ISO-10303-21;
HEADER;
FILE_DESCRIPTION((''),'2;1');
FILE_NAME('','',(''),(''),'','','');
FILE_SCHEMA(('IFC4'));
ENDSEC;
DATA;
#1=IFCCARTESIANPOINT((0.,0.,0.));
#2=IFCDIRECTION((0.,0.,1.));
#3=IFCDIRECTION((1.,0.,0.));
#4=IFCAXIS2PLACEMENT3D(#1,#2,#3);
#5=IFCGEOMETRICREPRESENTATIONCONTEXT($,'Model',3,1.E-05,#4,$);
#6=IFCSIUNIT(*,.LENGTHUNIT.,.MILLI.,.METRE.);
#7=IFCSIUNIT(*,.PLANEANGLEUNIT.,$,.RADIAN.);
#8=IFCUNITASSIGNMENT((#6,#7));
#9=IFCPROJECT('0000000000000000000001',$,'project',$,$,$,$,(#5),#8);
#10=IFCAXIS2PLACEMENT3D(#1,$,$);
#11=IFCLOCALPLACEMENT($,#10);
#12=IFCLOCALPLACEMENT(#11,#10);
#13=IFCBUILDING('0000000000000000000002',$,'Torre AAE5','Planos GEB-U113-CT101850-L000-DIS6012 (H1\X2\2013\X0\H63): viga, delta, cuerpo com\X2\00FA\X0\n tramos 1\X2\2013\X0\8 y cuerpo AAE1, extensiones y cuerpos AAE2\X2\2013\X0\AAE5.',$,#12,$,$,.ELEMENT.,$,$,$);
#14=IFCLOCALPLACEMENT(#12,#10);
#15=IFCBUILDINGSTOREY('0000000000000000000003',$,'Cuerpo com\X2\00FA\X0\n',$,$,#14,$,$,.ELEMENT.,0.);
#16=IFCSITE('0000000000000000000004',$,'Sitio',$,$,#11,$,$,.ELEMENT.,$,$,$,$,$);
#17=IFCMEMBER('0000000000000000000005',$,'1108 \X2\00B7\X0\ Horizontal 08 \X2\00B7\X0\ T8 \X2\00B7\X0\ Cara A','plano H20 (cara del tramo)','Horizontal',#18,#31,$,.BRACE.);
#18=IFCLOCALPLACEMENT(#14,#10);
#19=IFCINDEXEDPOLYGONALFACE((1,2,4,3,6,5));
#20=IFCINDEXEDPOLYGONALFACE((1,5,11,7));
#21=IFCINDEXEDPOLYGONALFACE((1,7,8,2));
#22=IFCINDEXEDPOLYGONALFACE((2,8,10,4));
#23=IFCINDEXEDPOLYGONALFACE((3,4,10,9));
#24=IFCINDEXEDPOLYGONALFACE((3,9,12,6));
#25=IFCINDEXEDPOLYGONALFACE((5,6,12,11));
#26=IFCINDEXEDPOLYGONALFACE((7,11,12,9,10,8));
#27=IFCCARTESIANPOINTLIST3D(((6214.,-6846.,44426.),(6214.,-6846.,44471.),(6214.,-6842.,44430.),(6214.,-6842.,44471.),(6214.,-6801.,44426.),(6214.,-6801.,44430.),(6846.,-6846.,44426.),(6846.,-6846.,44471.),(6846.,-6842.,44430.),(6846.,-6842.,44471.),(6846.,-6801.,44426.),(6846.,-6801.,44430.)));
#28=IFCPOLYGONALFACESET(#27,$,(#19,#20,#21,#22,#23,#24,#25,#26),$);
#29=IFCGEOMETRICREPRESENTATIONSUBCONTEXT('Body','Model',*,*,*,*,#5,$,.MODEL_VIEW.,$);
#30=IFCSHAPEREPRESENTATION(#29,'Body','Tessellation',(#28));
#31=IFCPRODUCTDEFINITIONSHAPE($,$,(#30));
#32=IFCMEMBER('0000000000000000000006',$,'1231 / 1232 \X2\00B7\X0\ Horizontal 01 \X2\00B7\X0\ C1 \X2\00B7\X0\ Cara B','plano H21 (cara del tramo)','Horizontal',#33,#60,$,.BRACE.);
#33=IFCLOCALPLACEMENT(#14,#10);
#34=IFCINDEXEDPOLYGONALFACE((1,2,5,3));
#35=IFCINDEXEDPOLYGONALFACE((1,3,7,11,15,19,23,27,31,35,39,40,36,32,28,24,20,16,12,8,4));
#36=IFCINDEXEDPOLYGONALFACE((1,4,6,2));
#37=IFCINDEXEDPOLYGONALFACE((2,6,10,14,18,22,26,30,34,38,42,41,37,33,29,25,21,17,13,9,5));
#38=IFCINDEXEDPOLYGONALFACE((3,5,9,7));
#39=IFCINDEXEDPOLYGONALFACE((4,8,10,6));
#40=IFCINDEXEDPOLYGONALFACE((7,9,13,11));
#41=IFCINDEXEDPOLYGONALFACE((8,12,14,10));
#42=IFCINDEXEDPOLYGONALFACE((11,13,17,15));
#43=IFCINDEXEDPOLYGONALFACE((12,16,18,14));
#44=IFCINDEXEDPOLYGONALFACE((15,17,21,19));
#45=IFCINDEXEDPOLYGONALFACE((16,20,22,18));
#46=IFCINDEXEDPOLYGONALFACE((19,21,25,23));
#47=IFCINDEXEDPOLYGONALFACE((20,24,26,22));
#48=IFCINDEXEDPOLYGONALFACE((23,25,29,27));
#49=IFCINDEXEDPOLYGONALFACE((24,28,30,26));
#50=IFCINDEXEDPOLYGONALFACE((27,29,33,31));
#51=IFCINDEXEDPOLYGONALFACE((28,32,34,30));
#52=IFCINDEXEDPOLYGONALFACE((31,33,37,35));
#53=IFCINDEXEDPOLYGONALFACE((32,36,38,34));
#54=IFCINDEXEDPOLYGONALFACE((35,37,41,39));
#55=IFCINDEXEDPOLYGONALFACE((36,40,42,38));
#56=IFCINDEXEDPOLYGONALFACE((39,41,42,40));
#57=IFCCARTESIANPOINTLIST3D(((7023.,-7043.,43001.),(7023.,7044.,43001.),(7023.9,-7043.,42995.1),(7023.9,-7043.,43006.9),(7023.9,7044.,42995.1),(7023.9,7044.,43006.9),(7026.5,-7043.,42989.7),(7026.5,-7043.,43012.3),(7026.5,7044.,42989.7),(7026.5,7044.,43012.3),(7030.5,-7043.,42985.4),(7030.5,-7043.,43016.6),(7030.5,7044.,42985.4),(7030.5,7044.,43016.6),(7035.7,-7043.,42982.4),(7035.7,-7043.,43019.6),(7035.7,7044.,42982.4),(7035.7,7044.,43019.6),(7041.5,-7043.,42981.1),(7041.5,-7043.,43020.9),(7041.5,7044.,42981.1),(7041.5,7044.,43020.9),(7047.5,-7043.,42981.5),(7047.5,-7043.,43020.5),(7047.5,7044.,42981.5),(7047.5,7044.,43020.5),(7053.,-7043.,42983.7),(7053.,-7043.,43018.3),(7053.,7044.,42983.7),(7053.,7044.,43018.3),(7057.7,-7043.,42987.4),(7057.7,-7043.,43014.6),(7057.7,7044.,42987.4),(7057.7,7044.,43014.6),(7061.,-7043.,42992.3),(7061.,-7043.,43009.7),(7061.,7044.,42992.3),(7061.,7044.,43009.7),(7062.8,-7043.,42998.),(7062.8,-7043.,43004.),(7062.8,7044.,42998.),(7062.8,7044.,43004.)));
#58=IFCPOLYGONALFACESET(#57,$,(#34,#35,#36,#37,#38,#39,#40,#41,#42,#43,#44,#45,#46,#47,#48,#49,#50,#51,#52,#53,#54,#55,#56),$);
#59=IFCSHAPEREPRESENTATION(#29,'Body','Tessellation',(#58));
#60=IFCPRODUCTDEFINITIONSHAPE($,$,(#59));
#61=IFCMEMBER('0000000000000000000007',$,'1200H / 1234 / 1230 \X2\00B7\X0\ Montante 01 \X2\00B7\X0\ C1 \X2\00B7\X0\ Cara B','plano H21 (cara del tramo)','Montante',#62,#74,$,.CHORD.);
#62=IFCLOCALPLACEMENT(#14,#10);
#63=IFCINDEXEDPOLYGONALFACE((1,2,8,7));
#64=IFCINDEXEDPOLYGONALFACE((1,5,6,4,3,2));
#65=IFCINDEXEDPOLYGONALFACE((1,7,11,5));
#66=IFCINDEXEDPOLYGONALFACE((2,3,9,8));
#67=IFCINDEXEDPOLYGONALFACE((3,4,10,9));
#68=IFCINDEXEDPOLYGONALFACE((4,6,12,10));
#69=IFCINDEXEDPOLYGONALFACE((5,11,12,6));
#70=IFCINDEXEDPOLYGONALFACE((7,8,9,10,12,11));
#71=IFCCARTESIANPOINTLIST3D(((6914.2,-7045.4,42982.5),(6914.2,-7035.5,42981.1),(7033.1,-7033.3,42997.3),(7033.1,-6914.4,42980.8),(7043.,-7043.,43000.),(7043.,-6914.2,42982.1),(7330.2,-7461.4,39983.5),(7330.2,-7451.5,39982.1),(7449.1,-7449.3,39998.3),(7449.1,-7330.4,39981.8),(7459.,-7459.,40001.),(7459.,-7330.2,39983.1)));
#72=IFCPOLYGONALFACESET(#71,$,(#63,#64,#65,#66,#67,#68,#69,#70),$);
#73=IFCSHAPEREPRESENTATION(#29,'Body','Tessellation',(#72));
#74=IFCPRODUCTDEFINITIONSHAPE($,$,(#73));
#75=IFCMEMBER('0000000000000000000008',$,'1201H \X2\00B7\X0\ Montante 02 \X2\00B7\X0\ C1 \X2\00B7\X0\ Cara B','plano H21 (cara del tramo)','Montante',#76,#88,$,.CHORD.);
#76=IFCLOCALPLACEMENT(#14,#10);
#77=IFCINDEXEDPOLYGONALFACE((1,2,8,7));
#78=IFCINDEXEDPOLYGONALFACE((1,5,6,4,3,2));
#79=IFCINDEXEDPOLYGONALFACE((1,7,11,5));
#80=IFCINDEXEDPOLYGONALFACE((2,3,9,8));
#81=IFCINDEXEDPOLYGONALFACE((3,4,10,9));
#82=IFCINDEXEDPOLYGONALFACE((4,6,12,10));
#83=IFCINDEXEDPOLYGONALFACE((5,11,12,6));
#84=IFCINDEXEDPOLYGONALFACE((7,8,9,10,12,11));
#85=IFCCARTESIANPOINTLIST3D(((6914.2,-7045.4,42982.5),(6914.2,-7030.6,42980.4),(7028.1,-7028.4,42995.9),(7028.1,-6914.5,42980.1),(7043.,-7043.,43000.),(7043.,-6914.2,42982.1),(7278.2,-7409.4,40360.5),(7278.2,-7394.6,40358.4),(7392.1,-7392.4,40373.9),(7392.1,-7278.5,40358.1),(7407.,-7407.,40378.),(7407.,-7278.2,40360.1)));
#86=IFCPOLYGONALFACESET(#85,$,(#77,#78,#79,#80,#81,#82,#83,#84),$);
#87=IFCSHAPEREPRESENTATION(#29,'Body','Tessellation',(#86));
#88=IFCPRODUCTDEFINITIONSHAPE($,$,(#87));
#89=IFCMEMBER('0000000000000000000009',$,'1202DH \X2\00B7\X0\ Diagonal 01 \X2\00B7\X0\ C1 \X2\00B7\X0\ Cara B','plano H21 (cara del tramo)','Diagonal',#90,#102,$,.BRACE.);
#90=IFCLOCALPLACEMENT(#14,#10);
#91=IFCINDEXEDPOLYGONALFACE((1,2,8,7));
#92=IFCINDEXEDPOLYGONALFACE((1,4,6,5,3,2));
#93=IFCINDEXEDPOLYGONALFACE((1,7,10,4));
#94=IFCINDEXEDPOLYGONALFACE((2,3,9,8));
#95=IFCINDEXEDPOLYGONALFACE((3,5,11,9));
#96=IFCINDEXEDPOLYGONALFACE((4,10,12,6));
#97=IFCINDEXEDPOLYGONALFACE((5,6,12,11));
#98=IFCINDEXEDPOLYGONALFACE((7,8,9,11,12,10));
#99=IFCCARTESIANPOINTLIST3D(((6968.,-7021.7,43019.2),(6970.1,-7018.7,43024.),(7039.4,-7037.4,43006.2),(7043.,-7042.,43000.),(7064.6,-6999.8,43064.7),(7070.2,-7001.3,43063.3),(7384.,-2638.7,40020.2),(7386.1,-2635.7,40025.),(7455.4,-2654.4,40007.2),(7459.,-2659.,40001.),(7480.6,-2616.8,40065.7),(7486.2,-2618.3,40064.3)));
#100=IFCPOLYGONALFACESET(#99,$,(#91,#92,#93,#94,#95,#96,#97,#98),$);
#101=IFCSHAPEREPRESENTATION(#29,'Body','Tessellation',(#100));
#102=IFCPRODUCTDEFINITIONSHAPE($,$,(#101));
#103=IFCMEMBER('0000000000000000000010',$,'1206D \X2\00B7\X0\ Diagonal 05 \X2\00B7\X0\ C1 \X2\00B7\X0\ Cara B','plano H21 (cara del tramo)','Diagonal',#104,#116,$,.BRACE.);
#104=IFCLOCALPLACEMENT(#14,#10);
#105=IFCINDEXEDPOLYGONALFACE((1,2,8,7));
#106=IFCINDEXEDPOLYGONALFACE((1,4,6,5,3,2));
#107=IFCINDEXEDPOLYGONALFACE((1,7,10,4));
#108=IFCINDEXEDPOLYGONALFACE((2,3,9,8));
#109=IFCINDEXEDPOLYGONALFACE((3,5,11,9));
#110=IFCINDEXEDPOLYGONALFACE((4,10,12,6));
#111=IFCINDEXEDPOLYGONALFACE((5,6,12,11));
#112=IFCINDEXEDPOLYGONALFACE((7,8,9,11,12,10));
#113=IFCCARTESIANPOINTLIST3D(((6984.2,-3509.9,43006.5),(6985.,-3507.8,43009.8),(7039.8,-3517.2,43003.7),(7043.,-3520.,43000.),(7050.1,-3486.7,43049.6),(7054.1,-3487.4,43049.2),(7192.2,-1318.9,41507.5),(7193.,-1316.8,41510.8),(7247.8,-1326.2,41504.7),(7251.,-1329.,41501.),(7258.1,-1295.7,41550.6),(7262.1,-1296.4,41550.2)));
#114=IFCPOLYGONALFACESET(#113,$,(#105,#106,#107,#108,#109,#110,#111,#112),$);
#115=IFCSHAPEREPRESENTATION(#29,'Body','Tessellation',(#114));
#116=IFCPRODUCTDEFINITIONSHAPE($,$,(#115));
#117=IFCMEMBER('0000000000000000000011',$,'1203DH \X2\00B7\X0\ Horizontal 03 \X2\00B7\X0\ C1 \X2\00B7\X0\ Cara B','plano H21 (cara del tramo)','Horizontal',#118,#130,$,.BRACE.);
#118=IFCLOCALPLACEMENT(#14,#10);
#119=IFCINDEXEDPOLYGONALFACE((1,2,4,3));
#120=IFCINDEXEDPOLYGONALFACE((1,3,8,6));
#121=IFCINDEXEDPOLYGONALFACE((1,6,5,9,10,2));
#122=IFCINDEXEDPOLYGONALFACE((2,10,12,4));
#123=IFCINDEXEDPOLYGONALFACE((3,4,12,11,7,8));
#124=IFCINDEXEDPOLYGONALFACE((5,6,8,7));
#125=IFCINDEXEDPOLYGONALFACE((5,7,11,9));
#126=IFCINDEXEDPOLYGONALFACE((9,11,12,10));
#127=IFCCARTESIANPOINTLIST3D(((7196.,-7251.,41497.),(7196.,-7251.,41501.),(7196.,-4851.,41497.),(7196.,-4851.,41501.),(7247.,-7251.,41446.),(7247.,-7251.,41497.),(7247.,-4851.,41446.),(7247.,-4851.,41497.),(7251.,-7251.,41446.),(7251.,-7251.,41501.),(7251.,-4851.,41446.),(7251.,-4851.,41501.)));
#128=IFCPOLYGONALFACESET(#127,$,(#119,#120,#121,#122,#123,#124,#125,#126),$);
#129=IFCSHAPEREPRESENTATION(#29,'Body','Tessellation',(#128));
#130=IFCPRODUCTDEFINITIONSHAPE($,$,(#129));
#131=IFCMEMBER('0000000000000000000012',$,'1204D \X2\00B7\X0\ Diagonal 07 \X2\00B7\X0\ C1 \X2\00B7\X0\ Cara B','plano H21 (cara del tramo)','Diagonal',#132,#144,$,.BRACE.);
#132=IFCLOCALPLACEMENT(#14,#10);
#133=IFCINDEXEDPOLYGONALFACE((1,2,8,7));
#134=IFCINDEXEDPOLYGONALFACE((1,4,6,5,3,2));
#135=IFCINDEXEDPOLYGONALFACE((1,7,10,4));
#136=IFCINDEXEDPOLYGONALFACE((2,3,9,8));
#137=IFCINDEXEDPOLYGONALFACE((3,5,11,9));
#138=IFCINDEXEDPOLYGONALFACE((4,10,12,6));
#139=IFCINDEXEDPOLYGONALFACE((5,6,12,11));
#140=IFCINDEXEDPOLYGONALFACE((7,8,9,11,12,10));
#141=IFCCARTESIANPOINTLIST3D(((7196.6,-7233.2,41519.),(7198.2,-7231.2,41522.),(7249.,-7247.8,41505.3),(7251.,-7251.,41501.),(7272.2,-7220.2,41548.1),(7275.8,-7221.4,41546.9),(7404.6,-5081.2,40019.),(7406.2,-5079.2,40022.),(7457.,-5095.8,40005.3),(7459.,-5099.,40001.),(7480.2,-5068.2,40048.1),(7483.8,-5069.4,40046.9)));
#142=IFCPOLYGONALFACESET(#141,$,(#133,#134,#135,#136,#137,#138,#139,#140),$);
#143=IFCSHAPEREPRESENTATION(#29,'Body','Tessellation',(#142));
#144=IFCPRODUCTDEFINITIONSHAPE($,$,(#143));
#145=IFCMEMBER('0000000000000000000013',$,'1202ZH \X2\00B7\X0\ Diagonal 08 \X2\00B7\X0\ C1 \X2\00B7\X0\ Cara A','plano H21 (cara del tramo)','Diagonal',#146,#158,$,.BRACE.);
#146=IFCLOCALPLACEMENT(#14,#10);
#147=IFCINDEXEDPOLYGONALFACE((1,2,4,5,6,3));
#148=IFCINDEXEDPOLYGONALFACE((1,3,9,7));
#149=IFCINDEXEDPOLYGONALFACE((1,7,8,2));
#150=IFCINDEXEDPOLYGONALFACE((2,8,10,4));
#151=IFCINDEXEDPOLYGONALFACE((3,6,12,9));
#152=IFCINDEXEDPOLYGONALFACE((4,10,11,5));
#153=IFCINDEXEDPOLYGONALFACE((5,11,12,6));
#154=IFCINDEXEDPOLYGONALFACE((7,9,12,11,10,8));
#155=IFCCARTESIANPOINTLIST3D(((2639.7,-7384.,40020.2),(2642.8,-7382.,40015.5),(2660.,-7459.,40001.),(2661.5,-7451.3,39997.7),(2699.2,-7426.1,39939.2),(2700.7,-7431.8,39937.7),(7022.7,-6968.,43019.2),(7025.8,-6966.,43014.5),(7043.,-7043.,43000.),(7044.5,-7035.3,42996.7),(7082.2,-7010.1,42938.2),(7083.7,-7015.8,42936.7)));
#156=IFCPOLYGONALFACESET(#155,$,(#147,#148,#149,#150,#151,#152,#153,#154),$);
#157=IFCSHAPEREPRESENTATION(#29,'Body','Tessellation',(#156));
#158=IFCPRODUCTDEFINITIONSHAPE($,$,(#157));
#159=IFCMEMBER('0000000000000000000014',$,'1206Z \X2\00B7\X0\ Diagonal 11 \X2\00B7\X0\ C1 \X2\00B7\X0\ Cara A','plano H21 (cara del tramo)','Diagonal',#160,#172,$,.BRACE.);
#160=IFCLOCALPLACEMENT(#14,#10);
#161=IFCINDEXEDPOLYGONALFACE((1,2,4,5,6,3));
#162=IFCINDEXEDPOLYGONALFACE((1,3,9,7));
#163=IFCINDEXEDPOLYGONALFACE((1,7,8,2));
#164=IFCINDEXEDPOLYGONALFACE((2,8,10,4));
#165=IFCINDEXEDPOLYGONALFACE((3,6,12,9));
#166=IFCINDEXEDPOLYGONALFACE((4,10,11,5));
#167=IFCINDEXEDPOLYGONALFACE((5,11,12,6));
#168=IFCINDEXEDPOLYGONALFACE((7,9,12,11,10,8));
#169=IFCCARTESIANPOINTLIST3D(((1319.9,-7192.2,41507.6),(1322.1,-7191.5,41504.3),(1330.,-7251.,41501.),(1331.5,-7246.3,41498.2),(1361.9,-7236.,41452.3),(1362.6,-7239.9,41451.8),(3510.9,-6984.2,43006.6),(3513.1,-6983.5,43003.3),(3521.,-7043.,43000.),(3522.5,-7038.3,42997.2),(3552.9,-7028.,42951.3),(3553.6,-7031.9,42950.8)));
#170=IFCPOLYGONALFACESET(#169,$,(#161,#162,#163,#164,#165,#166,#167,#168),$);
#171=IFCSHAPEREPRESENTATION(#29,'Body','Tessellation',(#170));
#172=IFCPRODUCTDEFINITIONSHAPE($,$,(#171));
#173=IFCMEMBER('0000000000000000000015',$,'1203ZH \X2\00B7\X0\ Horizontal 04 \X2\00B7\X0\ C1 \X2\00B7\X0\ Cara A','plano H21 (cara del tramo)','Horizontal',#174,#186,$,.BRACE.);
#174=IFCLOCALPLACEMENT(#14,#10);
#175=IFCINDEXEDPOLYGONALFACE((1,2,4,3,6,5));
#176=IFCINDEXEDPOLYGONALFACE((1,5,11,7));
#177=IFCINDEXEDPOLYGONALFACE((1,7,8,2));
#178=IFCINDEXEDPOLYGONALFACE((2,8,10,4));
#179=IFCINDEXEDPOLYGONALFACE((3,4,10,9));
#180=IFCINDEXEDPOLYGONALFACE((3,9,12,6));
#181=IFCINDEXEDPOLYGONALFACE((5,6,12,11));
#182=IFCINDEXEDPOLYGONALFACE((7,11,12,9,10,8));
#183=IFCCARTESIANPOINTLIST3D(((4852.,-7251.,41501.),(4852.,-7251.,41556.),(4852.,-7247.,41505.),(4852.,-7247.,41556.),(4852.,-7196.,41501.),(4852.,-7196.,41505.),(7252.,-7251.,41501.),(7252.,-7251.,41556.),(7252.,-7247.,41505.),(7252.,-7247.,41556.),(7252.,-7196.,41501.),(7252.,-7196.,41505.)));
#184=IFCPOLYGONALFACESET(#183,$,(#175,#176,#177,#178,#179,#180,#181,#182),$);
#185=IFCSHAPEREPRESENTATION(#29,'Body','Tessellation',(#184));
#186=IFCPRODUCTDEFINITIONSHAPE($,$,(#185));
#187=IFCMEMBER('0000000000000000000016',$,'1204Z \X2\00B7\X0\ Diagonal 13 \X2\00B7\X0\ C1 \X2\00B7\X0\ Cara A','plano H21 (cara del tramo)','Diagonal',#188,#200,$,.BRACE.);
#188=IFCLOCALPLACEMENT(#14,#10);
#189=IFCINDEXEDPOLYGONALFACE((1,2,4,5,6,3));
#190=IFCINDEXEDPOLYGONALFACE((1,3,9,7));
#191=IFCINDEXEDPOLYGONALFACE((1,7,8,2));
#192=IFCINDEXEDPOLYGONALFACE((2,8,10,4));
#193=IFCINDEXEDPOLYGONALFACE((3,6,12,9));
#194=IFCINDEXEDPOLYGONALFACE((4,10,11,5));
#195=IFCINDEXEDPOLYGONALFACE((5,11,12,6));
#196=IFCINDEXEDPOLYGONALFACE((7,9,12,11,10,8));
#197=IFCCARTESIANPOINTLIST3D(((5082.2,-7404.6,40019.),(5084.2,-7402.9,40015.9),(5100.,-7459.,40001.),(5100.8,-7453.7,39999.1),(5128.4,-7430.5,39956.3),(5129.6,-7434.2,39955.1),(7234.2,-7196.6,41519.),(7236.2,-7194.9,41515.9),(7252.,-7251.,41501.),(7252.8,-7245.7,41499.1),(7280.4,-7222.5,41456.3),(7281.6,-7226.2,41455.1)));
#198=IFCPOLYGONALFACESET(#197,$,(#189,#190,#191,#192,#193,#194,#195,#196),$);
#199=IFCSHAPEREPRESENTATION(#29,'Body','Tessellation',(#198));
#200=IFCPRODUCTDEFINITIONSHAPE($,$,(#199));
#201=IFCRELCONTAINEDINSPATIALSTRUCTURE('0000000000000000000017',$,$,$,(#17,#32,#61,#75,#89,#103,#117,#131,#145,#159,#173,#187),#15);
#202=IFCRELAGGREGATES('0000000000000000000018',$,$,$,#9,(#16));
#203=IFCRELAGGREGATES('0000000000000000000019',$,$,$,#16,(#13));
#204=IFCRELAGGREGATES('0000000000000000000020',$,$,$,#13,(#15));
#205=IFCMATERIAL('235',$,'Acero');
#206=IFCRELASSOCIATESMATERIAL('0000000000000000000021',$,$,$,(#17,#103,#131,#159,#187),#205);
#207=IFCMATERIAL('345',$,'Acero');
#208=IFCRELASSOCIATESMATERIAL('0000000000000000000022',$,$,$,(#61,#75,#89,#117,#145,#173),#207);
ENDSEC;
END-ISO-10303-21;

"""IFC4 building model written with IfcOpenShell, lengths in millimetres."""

from ifc_helpers import new_model, si_unit, frame, frame_2d, origin, origin_with_axes, place, context, subcontext, project, spatial, circle, l_section, extrude, material, element, save


model = new_model("IFC4")

# Units and contexts
model_context = context("Model", 3, precision=1e-05, world=origin_with_axes())
body_context = subcontext(model_context, "Body", "Model", "MODEL_VIEW")
ifc_project = project(units=[si_unit("LENGTHUNIT", "METRE", prefix="MILLI"), si_unit("PLANEANGLEUNIT", "RADIAN")], contexts=[model_context])

# Site, building, storey
site_placement = place(None, origin())
site = spatial("IfcSite", under=ifc_project, at=site_placement, Name="Sitio", CompositionType="ELEMENT")
building_placement = place(site_placement, origin())
building = spatial("IfcBuilding", under=site, at=building_placement, Name="Torre AAE5", Description="Planos GEB-U113-CT101850-L000-DIS6012 (H1–H63): viga, delta, cuerpo común tramos 1–8 y cuerpo AAE1, extensiones y cuerpos AAE2–AAE5.", CompositionType="ELEMENT")
storey_placement = place(building_placement, origin())
storey = spatial("IfcBuildingStorey", under=building, at=storey_placement, Name="Cuerpo común", CompositionType="ELEMENT", Elevation=0.0)

# Members
ifc_material_1 = material(Name="345", Category="Acero")
ifc_material_2 = material(Name="235", Category="Acero")
for number, where, z_axis, x_axis, name in (
    (1, (6214.0, -6846.0, 44426.0), (1.0, 0.0, 0.0), (0.0, 1.0, 0.0), "1108 · Horizontal 08 · T8 · Cara A"),
):
    element("IfcMember", number, at=place(storey_placement, frame(where, z_axis=z_axis, x_axis=x_axis)), inside=storey, material=ifc_material_2, Name=name, Description="plano H20 (cara del tramo)", ObjectType="Horizontal", PredefinedType="BRACE", context=body_context, shape_type="SweptSolid", body=[
        extrude(l_section(Depth=45.0, Width=45.0, Thickness=4.0, at=frame_2d((22.5, 22.5))), None, (0.0, 0.0, 1.0), 632.0),
    ])
member_1_placement = place(storey_placement, frame((7043.0, -7043.0, 43001.0), z_axis=(0.0, 1.0, 0.0), x_axis=(-1.0, 0.0, 0.0)))
element("IfcMember", 2, at=member_1_placement, inside=storey, Name="1231 / 1232 · Horizontal 01 · C1 · Cara B", Description="plano H21 (cara del tramo)", ObjectType="Horizontal", PredefinedType="BRACE", context=body_context, shape_type="SweptSolid", body=[
    extrude(circle(Radius=20.0), None, (0.0, 0.0, 1.0), 14087.0),
])
member_2_placement = place(storey_placement, frame((7043.0, -7043.0, 43000.0), z_axis=(0.136119, -0.136119, -0.981297), x_axis=(-0.990693, -0.018702, -0.134828)))
element("IfcMember", 3, at=member_2_placement, inside=storey, material=ifc_material_1, Name="1200H / 1234 / 1230 · Montante 01 · C1 · Cara B", Description="plano H21 (cara del tramo)", ObjectType="Montante", PredefinedType="CHORD", context=body_context, shape_type="SweptSolid", body=[
    extrude(l_section(Depth=130.0, Width=130.0, Thickness=10.0, at=frame_2d((65.0, 65.0))), None, (0.0, 0.0, 1.0), 3056.2),
])
member_3_placement = place(storey_placement, frame((7043.0, -7043.0, 43000.0), z_axis=(0.136225, -0.136225, -0.981267), x_axis=(-0.990678, -0.018732, -0.134931)))
element("IfcMember", 4, at=member_3_placement, inside=storey, material=ifc_material_1, Name="1201H · Montante 02 · C1 · Cara B", Description="plano H21 (cara del tramo)", ObjectType="Montante", PredefinedType="CHORD", context=body_context, shape_type="SweptSolid", body=[
    extrude(l_section(Depth=130.0, Width=130.0, Thickness=15.0, at=frame_2d((65.0, 65.0))), None, (0.0, 0.0, 1.0), 2672.1),
])
member_4_placement = place(storey_placement, frame((7043.0, -7042.0, 43000.0), z_axis=(0.078092, 0.822778, -0.562973), x_axis=(-0.937055, 0.253354, 0.240292)))
element("IfcMember", 5, at=member_4_placement, inside=storey, material=ifc_material_1, Name="1202DH · Diagonal 01 · C1 · Cara B", Description="plano H21 (cara del tramo)", ObjectType="Diagonal", PredefinedType="BRACE", context=body_context, shape_type="SweptSolid", body=[
    extrude(l_section(Depth=80.0, Width=80.0, Thickness=6.0, at=frame_2d((40.0, 40.0))), None, (0.0, 0.0, 1.0), 5327.1),
])
member_5_placement = place(storey_placement, frame((7043.0, -3520.0, 43000.0), z_axis=(0.078112, 0.822804, -0.562932), x_axis=(-0.979778, 0.167693, 0.109153)))
element("IfcMember", 6, at=member_5_placement, inside=storey, material=ifc_material_2, Name="1206D · Diagonal 05 · C1 · Cara B", Description="plano H21 (cara del tramo)", ObjectType="Diagonal", PredefinedType="BRACE", context=body_context, shape_type="SweptSolid", body=[
    extrude(l_section(Depth=60.0, Width=60.0, Thickness=4.0, at=frame_2d((30.0, 30.0))), None, (0.0, 0.0, 1.0), 2662.8),
])
member_6_placement = place(storey_placement, frame((7251.0, -4851.0, 41501.0), z_axis=(0.0, -1.0, 0.0), x_axis=(-1.0, 0.0, 0.0)))
element("IfcMember", 7, at=member_6_placement, inside=storey, material=ifc_material_1, Name="1203DH · Horizontal 03 · C1 · Cara B", Description="plano H21 (cara del tramo)", ObjectType="Horizontal", PredefinedType="BRACE", context=body_context, shape_type="SweptSolid", body=[
    extrude(l_section(Depth=55.0, Width=55.0, Thickness=4.0, at=frame_2d((27.5, 27.5))), None, (0.0, 0.0, 1.0), 2400.0),
])
member_7_placement = place(storey_placement, frame((7251.0, -7251.0, 41501.0), z_axis=(0.079045, 0.81781, -0.570035), x_axis=(-0.906797, 0.296517, 0.29966)))
element("IfcMember", 8, at=member_7_placement, inside=storey, material=ifc_material_2, Name="1204D · Diagonal 07 · C1 · Cara B", Description="plano H21 (cara del tramo)", ObjectType="Diagonal", PredefinedType="BRACE", context=body_context, shape_type="SweptSolid", body=[
    extrude(l_section(Depth=60.0, Width=60.0, Thickness=4.0, at=frame_2d((30.0, 30.0))), None, (0.0, 0.0, 1.0), 2631.4),
])
member_8_placement = place(storey_placement, frame((7043.0, -7043.0, 43000.0), z_axis=(-0.822778, -0.078092, -0.562973), x_axis=(-0.253386, 0.937033, 0.240342)))
element("IfcMember", 9, at=member_8_placement, inside=storey, material=ifc_material_1, Name="1202ZH · Diagonal 08 · C1 · Cara A", Description="plano H21 (cara del tramo)", ObjectType="Diagonal", PredefinedType="BRACE", context=body_context, shape_type="SweptSolid", body=[
    extrude(l_section(Depth=80.0, Width=80.0, Thickness=6.0, at=frame_2d((40.0, 40.0))), None, (0.0, 0.0, 1.0), 5327.1),
])
member_9_placement = place(storey_placement, frame((3521.0, -7043.0, 43000.0), z_axis=(-0.822804, -0.078112, -0.562932), x_axis=(-0.167732, 0.979764, 0.109213)))
element("IfcMember", 10, at=member_9_placement, inside=storey, material=ifc_material_2, Name="1206Z · Diagonal 11 · C1 · Cara A", Description="plano H21 (cara del tramo)", ObjectType="Diagonal", PredefinedType="BRACE", context=body_context, shape_type="SweptSolid", body=[
    extrude(l_section(Depth=60.0, Width=60.0, Thickness=4.0, at=frame_2d((30.0, 30.0))), None, (0.0, 0.0, 1.0), 2662.8),
])
member_10_placement = place(storey_placement, frame((4852.0, -7251.0, 41501.0), z_axis=(1.0, 0.0, 0.0), x_axis=(0.0, 1.0, 0.0)))
element("IfcMember", 11, at=member_10_placement, inside=storey, material=ifc_material_1, Name="1203ZH · Horizontal 04 · C1 · Cara A", Description="plano H21 (cara del tramo)", ObjectType="Horizontal", PredefinedType="BRACE", context=body_context, shape_type="SweptSolid", body=[
    extrude(l_section(Depth=55.0, Width=55.0, Thickness=4.0, at=frame_2d((27.5, 27.5))), None, (0.0, 0.0, 1.0), 2400.0),
])
member_11_placement = place(storey_placement, frame((7252.0, -7251.0, 41501.0), z_axis=(-0.81781, -0.079045, -0.570035), x_axis=(-0.296545, 0.906773, 0.299704)))
element("IfcMember", 12, at=member_11_placement, inside=storey, material=ifc_material_2, Name="1204Z · Diagonal 13 · C1 · Cara A", Description="plano H21 (cara del tramo)", ObjectType="Diagonal", PredefinedType="BRACE", context=body_context, shape_type="SweptSolid", body=[
    extrude(l_section(Depth=60.0, Width=60.0, Thickness=4.0, at=frame_2d((30.0, 30.0))), None, (0.0, 0.0, 1.0), 2631.4),
])

save(model, "model.ifc")
